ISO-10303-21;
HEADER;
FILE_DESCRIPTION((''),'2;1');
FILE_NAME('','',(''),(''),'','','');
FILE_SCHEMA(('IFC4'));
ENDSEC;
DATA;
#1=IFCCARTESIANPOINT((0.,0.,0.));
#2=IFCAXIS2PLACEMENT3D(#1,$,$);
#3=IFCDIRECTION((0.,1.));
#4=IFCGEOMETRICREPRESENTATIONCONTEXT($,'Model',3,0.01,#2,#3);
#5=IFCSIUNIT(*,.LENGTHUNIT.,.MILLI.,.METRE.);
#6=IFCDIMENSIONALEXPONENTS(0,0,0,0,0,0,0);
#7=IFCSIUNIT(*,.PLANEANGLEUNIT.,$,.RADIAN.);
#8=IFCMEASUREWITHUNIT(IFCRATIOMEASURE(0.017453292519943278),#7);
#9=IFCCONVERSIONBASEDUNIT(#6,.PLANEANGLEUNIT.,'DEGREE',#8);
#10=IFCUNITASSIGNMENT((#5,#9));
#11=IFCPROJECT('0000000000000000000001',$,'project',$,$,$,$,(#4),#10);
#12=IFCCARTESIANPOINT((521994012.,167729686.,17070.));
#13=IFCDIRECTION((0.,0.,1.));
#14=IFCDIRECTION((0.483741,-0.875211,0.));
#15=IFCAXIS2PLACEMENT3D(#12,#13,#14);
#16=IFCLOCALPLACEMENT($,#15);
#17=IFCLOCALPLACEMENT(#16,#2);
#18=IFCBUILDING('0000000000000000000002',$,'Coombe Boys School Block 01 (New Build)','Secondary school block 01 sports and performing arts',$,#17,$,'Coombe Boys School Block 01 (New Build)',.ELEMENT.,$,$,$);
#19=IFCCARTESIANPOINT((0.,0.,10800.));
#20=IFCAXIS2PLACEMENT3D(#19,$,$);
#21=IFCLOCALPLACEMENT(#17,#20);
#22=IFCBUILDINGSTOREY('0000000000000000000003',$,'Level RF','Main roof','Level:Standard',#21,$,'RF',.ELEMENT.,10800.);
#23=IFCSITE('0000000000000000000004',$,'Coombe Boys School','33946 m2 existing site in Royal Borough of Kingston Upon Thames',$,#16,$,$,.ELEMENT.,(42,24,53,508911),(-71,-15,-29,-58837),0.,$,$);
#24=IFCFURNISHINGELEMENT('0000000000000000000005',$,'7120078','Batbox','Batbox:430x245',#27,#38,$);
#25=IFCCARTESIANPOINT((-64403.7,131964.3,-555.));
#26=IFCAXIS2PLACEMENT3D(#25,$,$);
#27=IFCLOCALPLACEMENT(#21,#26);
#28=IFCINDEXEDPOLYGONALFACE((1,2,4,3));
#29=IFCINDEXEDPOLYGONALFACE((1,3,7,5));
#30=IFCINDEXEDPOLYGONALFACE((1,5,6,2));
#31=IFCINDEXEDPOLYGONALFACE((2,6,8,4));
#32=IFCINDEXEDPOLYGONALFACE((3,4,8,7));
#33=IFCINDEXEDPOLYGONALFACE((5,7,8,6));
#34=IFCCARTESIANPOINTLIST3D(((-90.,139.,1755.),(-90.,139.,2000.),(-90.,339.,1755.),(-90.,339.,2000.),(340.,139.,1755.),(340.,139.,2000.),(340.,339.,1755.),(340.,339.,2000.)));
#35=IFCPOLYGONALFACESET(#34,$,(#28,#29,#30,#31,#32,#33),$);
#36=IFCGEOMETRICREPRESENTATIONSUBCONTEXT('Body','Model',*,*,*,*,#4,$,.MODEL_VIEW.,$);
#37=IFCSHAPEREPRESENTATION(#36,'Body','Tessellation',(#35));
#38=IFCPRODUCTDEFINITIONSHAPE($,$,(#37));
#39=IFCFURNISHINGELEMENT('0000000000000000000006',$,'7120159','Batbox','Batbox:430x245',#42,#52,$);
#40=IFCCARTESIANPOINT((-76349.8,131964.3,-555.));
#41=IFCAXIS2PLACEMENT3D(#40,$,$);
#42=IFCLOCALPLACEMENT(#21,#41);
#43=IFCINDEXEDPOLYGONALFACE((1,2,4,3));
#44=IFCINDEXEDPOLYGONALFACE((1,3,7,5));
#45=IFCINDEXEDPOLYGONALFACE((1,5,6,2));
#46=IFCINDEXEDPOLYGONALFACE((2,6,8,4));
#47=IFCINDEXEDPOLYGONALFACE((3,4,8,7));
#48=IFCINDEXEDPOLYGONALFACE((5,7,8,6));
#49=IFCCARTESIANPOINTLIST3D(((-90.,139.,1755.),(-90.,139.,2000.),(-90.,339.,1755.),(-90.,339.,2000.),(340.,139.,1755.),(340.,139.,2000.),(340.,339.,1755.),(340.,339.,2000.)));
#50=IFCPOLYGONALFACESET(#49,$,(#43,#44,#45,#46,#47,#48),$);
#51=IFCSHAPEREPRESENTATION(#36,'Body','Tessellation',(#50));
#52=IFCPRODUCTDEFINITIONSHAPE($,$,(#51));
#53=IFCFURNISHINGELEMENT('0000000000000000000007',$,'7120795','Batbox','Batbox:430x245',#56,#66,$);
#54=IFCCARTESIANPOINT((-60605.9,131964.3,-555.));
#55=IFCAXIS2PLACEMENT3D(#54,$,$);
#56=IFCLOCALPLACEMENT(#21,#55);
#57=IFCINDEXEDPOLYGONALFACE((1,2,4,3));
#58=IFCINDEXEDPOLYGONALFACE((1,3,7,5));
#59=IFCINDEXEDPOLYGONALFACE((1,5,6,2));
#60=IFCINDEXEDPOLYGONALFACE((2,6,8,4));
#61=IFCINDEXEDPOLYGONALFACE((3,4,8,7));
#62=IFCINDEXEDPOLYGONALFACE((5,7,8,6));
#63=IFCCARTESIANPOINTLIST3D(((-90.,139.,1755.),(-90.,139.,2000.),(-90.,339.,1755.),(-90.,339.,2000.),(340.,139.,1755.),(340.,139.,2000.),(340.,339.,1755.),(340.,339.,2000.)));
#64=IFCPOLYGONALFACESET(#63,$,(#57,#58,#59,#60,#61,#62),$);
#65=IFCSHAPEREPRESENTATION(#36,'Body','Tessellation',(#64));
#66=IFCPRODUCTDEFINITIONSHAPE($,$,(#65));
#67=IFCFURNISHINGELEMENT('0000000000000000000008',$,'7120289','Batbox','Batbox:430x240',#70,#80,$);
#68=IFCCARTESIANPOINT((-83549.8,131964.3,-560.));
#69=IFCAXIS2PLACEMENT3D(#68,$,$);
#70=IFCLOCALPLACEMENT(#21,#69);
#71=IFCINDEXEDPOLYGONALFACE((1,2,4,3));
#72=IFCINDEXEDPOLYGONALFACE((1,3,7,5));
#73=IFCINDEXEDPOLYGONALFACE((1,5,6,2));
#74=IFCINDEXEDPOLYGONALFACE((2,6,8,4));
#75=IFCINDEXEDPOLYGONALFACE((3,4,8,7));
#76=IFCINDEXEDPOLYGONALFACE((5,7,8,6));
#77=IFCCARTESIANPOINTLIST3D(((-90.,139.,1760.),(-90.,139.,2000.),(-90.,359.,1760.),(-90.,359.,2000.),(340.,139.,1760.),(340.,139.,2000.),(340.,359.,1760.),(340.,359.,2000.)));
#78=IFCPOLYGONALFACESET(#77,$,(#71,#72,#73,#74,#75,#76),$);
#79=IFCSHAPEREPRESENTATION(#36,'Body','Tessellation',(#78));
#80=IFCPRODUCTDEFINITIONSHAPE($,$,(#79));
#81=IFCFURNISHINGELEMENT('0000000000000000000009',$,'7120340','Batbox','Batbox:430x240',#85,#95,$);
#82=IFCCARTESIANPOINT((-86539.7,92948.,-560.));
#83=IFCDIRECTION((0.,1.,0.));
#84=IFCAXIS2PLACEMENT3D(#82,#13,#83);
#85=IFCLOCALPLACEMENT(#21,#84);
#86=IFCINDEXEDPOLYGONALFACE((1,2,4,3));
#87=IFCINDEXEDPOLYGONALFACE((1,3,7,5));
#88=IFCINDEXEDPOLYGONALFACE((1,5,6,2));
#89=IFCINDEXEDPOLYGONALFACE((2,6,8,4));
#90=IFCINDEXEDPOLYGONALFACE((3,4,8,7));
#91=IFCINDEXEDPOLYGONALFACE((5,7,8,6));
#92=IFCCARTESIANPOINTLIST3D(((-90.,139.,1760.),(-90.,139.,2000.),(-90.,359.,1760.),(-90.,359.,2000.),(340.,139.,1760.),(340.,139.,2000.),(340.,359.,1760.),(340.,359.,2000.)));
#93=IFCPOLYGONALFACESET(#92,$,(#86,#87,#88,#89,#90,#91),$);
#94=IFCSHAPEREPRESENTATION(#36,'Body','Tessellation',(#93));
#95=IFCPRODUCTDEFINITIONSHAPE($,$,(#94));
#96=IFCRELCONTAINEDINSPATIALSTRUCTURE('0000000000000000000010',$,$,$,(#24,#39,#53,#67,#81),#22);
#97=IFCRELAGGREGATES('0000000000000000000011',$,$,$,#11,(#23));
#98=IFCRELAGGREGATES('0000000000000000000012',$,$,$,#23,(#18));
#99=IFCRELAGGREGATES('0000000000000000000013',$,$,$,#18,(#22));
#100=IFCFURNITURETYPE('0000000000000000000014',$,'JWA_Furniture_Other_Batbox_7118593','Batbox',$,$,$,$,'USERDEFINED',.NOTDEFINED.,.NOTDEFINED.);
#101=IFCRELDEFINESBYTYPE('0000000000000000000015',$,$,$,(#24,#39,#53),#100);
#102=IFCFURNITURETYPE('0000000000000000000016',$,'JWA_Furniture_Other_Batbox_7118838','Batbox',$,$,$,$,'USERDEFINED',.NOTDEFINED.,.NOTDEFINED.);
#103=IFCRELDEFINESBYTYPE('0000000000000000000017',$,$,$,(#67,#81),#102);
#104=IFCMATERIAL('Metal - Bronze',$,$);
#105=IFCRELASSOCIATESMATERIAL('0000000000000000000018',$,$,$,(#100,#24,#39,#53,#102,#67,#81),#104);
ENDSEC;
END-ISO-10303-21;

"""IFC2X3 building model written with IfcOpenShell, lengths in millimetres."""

from ifc_helpers import new_model, entity, si_unit, converted_unit, direction, frame, origin, origin_2d_with_axis, place, context, subcontext, project, spatial, rectangle, extrude, source, transform, mapped, material, type_object, type_shapes, element, save


model = new_model("IFC2X3")

# Units and contexts
model_context = context("Model", 3, precision=0.01, world=origin(), true_north=direction((0.0, 1.0)))
body_context = subcontext(model_context, "Body", "Model", "MODEL_VIEW")
ifc_project = project(units=[si_unit("LENGTHUNIT", "METRE", prefix="MILLI"), converted_unit("PLANEANGLEUNIT", "DEGREE", entity("IfcRatioMeasure", 0.017453292519943278), si_unit("PLANEANGLEUNIT", "RADIAN"), dimensions=[0, 0, 0, 0, 0, 0, 0])], contexts=[model_context])

# Site, building, storey
site_placement = place(None, frame((521994012.0, 167729686.0, 17070.0), z_axis=(0.0, 0.0, 1.0), x_axis=(0.483741, -0.875211, 0.0)))
site = spatial("IfcSite", under=ifc_project, at=site_placement, Name="Coombe Boys School", Description="33946 m2 existing site in Royal Borough of Kingston Upon Thames", CompositionType="ELEMENT", RefLatitude=(42, 24, 53, 508911), RefLongitude=(-71, -15, -29, -58837), RefElevation=0.0)
building_placement = place(site_placement, origin())
building = spatial("IfcBuilding", under=site, at=building_placement, Name="Coombe Boys School Block 01 (New Build)", Description="Secondary school block 01 sports and performing arts", LongName="Coombe Boys School Block 01 (New Build)", CompositionType="ELEMENT")
storey_placement = place(building_placement, frame((0.0, 0.0, 10800.0)))
storey = spatial("IfcBuildingStorey", under=building, at=storey_placement, Name="Level RF", Description="Main roof", ObjectType="Level:Standard", LongName="RF", CompositionType="ELEMENT", Elevation=10800.0)

# Furnishing elements
ifc_material_1 = material(Name="Metal - Bronze")
furniture_type_1 = type_object("IfcFurnitureType", Name="JWA_Furniture_Other_Batbox_7118593", Description="Batbox", ElementType="USERDEFINED", material=ifc_material_1)
shared_shape_1 = source(origin(), body_context, "Body", "SweptSolid", [
    extrude(rectangle(XDim=200.0, YDim=430.0, at=origin_2d_with_axis()), frame((125.0, 239.0, 1755.0), z_axis=(0.0, 0.0, 1.0), x_axis=(0.0, -1.0, 0.0)), (0.0, 0.0, 1.0), 245.0),
])
type_shapes(furniture_type_1, [shared_shape_1])
for number, where, name in (
    (1, (-64403.7, 131964.3, -555.0), "7120078"),
    (2, (-76349.8, 131964.3, -555.0), "7120159"),
    (3, (-60605.9, 131964.3, -555.0), "7120795"),
):
    element("IfcFurnishingElement", number, at=place(storey_placement, frame(where)), inside=storey, type_object=furniture_type_1, material=ifc_material_1, Name=name, Description="Batbox", ObjectType="Batbox:430x245", context=body_context, shape_type="MappedRepresentation", body=[
        mapped(shared_shape_1, transform((0.0, 0.0, 0.0), scale=1.0)),
    ])
furniture_type_2 = type_object("IfcFurnitureType", Name="JWA_Furniture_Other_Batbox_7118838", Description="Batbox", ElementType="USERDEFINED", material=ifc_material_1)
shared_shape_2 = source(origin(), body_context, "Body", "SweptSolid", [
    extrude(rectangle(XDim=220.0, YDim=430.0, at=origin_2d_with_axis()), frame((125.0, 249.0, 1760.0), z_axis=(0.0, 0.0, 1.0), x_axis=(0.0, -1.0, 0.0)), (0.0, 0.0, 1.0), 240.0),
])
type_shapes(furniture_type_2, [shared_shape_2])
furnishing_1_placement = place(storey_placement, frame((-83549.8, 131964.3, -560.0)))
element("IfcFurnishingElement", 4, at=furnishing_1_placement, inside=storey, type_object=furniture_type_2, material=ifc_material_1, Name="7120289", Description="Batbox", ObjectType="Batbox:430x240", context=body_context, shape_type="MappedRepresentation", body=[
    mapped(shared_shape_2, transform((0.0, 0.0, 0.0), scale=1.0)),
])
furnishing_2_placement = place(storey_placement, frame((-86539.7, 92948.0, -560.0), z_axis=(0.0, 0.0, 1.0), x_axis=(0.0, 1.0, 0.0)))
element("IfcFurnishingElement", 5, at=furnishing_2_placement, inside=storey, type_object=furniture_type_2, material=ifc_material_1, Name="7120340", Description="Batbox", ObjectType="Batbox:430x240", context=body_context, shape_type="MappedRepresentation", body=[
    mapped(shared_shape_2, transform((0.0, 0.0, 0.0), scale=1.0)),
])

save(model, "model.ifc")
